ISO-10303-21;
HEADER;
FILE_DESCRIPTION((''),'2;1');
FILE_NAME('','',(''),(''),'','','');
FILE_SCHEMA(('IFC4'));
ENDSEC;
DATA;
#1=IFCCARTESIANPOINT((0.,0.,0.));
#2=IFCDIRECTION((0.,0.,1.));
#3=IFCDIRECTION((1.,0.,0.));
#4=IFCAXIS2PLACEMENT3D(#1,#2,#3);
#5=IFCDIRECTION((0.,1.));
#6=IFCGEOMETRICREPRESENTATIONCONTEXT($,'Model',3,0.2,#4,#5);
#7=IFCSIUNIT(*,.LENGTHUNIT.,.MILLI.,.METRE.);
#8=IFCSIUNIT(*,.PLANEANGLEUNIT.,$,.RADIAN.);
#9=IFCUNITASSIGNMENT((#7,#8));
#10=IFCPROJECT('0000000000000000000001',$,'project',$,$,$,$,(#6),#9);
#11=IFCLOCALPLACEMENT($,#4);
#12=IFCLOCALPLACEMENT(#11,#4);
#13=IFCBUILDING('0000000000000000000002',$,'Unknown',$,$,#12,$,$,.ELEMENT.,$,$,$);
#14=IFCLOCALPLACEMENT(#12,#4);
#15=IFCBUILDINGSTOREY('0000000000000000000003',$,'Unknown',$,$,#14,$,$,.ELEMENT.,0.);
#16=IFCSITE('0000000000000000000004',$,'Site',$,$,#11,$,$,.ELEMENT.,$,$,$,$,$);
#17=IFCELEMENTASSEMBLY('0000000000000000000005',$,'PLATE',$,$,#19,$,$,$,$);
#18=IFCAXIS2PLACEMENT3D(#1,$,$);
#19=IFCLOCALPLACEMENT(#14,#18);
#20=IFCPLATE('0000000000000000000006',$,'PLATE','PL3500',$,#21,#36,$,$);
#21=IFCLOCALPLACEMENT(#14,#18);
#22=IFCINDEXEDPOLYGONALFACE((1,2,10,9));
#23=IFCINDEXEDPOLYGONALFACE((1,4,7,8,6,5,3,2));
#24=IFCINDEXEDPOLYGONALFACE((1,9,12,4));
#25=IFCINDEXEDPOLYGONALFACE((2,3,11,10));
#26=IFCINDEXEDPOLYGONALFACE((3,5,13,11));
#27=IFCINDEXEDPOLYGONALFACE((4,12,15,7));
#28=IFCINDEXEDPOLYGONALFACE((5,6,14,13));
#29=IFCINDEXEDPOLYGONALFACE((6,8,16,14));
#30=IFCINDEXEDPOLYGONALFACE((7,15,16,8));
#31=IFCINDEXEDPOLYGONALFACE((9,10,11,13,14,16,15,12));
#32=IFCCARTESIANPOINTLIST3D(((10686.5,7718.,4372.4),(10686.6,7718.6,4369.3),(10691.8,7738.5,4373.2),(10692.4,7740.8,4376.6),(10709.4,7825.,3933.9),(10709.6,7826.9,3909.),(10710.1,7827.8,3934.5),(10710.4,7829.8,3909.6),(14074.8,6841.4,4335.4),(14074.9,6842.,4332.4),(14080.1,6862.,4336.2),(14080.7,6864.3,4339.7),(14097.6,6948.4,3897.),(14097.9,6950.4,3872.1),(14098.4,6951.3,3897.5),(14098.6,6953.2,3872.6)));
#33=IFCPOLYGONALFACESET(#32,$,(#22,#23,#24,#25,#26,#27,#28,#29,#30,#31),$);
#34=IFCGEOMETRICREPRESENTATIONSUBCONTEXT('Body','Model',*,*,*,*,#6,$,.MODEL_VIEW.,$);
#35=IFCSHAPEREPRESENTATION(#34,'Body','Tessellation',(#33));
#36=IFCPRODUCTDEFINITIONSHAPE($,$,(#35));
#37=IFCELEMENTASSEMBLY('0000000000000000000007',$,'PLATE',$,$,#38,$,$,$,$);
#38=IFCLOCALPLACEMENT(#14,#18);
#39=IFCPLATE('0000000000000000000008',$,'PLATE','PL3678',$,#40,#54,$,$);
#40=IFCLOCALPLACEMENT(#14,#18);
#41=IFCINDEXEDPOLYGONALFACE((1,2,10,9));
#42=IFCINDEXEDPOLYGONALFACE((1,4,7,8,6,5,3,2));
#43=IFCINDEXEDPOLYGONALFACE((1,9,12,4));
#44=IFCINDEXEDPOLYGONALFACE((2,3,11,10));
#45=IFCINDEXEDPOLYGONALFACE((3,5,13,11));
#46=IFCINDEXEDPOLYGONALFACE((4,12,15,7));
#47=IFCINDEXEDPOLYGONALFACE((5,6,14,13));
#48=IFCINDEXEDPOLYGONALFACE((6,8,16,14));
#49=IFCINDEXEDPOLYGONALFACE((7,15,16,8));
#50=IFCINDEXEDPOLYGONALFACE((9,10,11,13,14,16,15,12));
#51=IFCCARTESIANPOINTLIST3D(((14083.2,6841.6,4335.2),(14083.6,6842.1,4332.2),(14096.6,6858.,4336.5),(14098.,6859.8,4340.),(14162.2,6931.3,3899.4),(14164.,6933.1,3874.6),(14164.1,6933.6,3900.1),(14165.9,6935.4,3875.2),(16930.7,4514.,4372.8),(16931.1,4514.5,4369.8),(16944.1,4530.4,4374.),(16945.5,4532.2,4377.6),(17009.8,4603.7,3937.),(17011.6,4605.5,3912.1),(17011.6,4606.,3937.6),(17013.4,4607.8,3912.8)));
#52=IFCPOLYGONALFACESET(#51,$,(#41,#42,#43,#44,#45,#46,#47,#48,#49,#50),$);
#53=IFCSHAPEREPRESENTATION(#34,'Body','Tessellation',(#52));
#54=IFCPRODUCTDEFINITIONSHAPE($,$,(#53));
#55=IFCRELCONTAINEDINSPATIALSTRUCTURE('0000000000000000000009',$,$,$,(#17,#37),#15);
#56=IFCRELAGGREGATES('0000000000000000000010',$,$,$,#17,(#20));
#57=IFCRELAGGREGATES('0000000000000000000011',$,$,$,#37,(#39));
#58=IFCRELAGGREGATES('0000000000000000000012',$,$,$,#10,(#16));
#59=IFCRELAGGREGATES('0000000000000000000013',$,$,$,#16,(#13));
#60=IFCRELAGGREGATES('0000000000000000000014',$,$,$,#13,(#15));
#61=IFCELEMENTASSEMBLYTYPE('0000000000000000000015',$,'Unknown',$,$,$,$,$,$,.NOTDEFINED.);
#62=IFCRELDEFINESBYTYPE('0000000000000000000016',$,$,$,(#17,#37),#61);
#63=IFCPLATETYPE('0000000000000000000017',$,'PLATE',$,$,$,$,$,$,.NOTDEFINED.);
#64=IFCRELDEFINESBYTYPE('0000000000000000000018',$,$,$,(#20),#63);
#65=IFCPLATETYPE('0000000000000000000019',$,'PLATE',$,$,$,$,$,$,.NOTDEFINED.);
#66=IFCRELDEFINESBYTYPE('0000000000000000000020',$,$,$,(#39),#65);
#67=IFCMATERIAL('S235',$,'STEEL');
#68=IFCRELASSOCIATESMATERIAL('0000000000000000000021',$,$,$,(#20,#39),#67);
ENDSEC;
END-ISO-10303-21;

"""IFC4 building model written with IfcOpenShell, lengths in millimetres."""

from ifc_helpers import new_model, si_unit, direction, frame, origin_with_axes, place, context, subcontext, project, spatial, line, indexed_curve, outline, extrude, material, material_profile, profile_set, profile_usage, type_object, element, aggregate, save


model = new_model("IFC4")

# Units and contexts
model_context = context("Model", 3, precision=0.2, world=origin_with_axes(), true_north=direction((0.0, 1.0)))
body_context = subcontext(model_context, "Body", "Model", "MODEL_VIEW")
ifc_project = project(units=[si_unit("LENGTHUNIT", "METRE", prefix="MILLI"), si_unit("PLANEANGLEUNIT", "RADIAN")], contexts=[model_context])

# Site, building, storey
site_placement = place(None, origin_with_axes())
site = spatial("IfcSite", under=ifc_project, at=site_placement, Name="Site", CompositionType="ELEMENT")
building_placement = place(site_placement, origin_with_axes())
building = spatial("IfcBuilding", under=site, at=building_placement, Name="Unknown", CompositionType="ELEMENT")
storey_placement = place(building_placement, origin_with_axes())
storey = spatial("IfcBuildingStorey", under=building, at=storey_placement, Name="Unknown", CompositionType="ELEMENT", Elevation=0.0)

# Shared definitions
element_assembly_type = type_object("IfcElementAssemblyType", Name="Unknown", PredefinedType="NOTDEFINED")

# Shared definitions
ifc_material_1 = material(Name="S235", Category="STEEL")

# Element assemblies, plates
assembly_1_placement = place(storey_placement, frame((12380.6, 7279.7, 4353.9), z_axis=(-0.968075, 0.25044, 0.010562), x_axis=(0.248264, 0.952146, 0.178279)))
assembly_1 = element("IfcElementAssembly", 1, at=assembly_1_placement, inside=storey, type_object=element_assembly_type, Name="PLATE")
ifc_material_profile_1 = material_profile(ifc_material_1, outline(indexed_curve([(0.0, 0.0), (24.0, 0.0), (32.4, 450.9), (29.8, 475.8), (26.9, 475.8), (29.4, 450.9), (21.0, 3.0), (0.0, 3.1)], segments=[line(1, 2, 3, 4, 5, 6, 7, 8, 1)])), Name="PL3500")
ifc_profile_set_1 = profile_set([ifc_material_profile_1])
ifc_profile_usage_1 = profile_usage(ifc_profile_set_1, cardinal=5)
plate_type_1 = type_object("IfcPlateType", Name="PLATE", PredefinedType="NOTDEFINED")
plate_1_placement = place(assembly_1_placement, origin_with_axes())
plate_1 = element("IfcPlate", 2, at=plate_1_placement, type_object=plate_type_1, material=ifc_profile_usage_1, Name="PLATE", Description="PL3500", context=body_context, shape_type="SolidModel", body=[
    extrude(outline(indexed_curve([(0.0, 0.0), (24.0, 0.0), (32.4, 450.9), (29.8, 475.8), (26.9, 475.8), (29.4, 450.9), (21.0, 3.0), (0.0, 3.1)], segments=[line(1, 2, 3, 4, 5, 6, 7, 8, 1)])), frame((0.0, 0.0, 1750.0), z_axis=(0.0, 0.0, 1.0), x_axis=(1.0, 0.0, 0.0)), (0.0, 0.0, -1.0), 3500.0),
])
aggregate(assembly_1, [plate_1])
assembly_2_placement = place(storey_placement, frame((15506.9, 5677.8, 4354.0), z_axis=(-0.774211, 0.632845, -0.010213), x_axis=(0.618347, 0.759722, 0.20117)))
assembly_2 = element("IfcElementAssembly", 3, at=assembly_2_placement, inside=storey, type_object=element_assembly_type, Name="PLATE")
ifc_material_profile_2 = material_profile(ifc_material_1, outline(indexed_curve([(0.0, 0.0), (24.0, 0.0), (32.4, 450.9), (29.8, 475.8), (26.9, 475.8), (29.4, 450.9), (21.0, 3.0), (0.0, 3.1)], segments=[line(1, 2, 3, 4, 5, 6, 7, 8, 1)])), Name="PL3678")
ifc_profile_set_2 = profile_set([ifc_material_profile_2])
ifc_profile_usage_2 = profile_usage(ifc_profile_set_2, cardinal=5)
plate_type_2 = type_object("IfcPlateType", Name="PLATE", PredefinedType="NOTDEFINED")
plate_2_placement = place(assembly_2_placement, origin_with_axes())
plate_2 = element("IfcPlate", 4, at=plate_2_placement, type_object=plate_type_2, material=ifc_profile_usage_2, Name="PLATE", Description="PL3678", context=body_context, shape_type="SolidModel", body=[
    extrude(outline(indexed_curve([(0.0, 0.0), (24.0, 0.0), (32.4, 450.9), (29.8, 475.8), (26.9, 475.8), (29.4, 450.9), (21.0, 3.0), (0.0, 3.1)], segments=[line(1, 2, 3, 4, 5, 6, 7, 8, 1)])), frame((0.0, 0.0, 1839.0), z_axis=(0.0, 0.0, 1.0), x_axis=(1.0, 0.0, 0.0)), (0.0, 0.0, -1.0), 3678.0),
])
aggregate(assembly_2, [plate_2])

save(model, "model.ifc")
